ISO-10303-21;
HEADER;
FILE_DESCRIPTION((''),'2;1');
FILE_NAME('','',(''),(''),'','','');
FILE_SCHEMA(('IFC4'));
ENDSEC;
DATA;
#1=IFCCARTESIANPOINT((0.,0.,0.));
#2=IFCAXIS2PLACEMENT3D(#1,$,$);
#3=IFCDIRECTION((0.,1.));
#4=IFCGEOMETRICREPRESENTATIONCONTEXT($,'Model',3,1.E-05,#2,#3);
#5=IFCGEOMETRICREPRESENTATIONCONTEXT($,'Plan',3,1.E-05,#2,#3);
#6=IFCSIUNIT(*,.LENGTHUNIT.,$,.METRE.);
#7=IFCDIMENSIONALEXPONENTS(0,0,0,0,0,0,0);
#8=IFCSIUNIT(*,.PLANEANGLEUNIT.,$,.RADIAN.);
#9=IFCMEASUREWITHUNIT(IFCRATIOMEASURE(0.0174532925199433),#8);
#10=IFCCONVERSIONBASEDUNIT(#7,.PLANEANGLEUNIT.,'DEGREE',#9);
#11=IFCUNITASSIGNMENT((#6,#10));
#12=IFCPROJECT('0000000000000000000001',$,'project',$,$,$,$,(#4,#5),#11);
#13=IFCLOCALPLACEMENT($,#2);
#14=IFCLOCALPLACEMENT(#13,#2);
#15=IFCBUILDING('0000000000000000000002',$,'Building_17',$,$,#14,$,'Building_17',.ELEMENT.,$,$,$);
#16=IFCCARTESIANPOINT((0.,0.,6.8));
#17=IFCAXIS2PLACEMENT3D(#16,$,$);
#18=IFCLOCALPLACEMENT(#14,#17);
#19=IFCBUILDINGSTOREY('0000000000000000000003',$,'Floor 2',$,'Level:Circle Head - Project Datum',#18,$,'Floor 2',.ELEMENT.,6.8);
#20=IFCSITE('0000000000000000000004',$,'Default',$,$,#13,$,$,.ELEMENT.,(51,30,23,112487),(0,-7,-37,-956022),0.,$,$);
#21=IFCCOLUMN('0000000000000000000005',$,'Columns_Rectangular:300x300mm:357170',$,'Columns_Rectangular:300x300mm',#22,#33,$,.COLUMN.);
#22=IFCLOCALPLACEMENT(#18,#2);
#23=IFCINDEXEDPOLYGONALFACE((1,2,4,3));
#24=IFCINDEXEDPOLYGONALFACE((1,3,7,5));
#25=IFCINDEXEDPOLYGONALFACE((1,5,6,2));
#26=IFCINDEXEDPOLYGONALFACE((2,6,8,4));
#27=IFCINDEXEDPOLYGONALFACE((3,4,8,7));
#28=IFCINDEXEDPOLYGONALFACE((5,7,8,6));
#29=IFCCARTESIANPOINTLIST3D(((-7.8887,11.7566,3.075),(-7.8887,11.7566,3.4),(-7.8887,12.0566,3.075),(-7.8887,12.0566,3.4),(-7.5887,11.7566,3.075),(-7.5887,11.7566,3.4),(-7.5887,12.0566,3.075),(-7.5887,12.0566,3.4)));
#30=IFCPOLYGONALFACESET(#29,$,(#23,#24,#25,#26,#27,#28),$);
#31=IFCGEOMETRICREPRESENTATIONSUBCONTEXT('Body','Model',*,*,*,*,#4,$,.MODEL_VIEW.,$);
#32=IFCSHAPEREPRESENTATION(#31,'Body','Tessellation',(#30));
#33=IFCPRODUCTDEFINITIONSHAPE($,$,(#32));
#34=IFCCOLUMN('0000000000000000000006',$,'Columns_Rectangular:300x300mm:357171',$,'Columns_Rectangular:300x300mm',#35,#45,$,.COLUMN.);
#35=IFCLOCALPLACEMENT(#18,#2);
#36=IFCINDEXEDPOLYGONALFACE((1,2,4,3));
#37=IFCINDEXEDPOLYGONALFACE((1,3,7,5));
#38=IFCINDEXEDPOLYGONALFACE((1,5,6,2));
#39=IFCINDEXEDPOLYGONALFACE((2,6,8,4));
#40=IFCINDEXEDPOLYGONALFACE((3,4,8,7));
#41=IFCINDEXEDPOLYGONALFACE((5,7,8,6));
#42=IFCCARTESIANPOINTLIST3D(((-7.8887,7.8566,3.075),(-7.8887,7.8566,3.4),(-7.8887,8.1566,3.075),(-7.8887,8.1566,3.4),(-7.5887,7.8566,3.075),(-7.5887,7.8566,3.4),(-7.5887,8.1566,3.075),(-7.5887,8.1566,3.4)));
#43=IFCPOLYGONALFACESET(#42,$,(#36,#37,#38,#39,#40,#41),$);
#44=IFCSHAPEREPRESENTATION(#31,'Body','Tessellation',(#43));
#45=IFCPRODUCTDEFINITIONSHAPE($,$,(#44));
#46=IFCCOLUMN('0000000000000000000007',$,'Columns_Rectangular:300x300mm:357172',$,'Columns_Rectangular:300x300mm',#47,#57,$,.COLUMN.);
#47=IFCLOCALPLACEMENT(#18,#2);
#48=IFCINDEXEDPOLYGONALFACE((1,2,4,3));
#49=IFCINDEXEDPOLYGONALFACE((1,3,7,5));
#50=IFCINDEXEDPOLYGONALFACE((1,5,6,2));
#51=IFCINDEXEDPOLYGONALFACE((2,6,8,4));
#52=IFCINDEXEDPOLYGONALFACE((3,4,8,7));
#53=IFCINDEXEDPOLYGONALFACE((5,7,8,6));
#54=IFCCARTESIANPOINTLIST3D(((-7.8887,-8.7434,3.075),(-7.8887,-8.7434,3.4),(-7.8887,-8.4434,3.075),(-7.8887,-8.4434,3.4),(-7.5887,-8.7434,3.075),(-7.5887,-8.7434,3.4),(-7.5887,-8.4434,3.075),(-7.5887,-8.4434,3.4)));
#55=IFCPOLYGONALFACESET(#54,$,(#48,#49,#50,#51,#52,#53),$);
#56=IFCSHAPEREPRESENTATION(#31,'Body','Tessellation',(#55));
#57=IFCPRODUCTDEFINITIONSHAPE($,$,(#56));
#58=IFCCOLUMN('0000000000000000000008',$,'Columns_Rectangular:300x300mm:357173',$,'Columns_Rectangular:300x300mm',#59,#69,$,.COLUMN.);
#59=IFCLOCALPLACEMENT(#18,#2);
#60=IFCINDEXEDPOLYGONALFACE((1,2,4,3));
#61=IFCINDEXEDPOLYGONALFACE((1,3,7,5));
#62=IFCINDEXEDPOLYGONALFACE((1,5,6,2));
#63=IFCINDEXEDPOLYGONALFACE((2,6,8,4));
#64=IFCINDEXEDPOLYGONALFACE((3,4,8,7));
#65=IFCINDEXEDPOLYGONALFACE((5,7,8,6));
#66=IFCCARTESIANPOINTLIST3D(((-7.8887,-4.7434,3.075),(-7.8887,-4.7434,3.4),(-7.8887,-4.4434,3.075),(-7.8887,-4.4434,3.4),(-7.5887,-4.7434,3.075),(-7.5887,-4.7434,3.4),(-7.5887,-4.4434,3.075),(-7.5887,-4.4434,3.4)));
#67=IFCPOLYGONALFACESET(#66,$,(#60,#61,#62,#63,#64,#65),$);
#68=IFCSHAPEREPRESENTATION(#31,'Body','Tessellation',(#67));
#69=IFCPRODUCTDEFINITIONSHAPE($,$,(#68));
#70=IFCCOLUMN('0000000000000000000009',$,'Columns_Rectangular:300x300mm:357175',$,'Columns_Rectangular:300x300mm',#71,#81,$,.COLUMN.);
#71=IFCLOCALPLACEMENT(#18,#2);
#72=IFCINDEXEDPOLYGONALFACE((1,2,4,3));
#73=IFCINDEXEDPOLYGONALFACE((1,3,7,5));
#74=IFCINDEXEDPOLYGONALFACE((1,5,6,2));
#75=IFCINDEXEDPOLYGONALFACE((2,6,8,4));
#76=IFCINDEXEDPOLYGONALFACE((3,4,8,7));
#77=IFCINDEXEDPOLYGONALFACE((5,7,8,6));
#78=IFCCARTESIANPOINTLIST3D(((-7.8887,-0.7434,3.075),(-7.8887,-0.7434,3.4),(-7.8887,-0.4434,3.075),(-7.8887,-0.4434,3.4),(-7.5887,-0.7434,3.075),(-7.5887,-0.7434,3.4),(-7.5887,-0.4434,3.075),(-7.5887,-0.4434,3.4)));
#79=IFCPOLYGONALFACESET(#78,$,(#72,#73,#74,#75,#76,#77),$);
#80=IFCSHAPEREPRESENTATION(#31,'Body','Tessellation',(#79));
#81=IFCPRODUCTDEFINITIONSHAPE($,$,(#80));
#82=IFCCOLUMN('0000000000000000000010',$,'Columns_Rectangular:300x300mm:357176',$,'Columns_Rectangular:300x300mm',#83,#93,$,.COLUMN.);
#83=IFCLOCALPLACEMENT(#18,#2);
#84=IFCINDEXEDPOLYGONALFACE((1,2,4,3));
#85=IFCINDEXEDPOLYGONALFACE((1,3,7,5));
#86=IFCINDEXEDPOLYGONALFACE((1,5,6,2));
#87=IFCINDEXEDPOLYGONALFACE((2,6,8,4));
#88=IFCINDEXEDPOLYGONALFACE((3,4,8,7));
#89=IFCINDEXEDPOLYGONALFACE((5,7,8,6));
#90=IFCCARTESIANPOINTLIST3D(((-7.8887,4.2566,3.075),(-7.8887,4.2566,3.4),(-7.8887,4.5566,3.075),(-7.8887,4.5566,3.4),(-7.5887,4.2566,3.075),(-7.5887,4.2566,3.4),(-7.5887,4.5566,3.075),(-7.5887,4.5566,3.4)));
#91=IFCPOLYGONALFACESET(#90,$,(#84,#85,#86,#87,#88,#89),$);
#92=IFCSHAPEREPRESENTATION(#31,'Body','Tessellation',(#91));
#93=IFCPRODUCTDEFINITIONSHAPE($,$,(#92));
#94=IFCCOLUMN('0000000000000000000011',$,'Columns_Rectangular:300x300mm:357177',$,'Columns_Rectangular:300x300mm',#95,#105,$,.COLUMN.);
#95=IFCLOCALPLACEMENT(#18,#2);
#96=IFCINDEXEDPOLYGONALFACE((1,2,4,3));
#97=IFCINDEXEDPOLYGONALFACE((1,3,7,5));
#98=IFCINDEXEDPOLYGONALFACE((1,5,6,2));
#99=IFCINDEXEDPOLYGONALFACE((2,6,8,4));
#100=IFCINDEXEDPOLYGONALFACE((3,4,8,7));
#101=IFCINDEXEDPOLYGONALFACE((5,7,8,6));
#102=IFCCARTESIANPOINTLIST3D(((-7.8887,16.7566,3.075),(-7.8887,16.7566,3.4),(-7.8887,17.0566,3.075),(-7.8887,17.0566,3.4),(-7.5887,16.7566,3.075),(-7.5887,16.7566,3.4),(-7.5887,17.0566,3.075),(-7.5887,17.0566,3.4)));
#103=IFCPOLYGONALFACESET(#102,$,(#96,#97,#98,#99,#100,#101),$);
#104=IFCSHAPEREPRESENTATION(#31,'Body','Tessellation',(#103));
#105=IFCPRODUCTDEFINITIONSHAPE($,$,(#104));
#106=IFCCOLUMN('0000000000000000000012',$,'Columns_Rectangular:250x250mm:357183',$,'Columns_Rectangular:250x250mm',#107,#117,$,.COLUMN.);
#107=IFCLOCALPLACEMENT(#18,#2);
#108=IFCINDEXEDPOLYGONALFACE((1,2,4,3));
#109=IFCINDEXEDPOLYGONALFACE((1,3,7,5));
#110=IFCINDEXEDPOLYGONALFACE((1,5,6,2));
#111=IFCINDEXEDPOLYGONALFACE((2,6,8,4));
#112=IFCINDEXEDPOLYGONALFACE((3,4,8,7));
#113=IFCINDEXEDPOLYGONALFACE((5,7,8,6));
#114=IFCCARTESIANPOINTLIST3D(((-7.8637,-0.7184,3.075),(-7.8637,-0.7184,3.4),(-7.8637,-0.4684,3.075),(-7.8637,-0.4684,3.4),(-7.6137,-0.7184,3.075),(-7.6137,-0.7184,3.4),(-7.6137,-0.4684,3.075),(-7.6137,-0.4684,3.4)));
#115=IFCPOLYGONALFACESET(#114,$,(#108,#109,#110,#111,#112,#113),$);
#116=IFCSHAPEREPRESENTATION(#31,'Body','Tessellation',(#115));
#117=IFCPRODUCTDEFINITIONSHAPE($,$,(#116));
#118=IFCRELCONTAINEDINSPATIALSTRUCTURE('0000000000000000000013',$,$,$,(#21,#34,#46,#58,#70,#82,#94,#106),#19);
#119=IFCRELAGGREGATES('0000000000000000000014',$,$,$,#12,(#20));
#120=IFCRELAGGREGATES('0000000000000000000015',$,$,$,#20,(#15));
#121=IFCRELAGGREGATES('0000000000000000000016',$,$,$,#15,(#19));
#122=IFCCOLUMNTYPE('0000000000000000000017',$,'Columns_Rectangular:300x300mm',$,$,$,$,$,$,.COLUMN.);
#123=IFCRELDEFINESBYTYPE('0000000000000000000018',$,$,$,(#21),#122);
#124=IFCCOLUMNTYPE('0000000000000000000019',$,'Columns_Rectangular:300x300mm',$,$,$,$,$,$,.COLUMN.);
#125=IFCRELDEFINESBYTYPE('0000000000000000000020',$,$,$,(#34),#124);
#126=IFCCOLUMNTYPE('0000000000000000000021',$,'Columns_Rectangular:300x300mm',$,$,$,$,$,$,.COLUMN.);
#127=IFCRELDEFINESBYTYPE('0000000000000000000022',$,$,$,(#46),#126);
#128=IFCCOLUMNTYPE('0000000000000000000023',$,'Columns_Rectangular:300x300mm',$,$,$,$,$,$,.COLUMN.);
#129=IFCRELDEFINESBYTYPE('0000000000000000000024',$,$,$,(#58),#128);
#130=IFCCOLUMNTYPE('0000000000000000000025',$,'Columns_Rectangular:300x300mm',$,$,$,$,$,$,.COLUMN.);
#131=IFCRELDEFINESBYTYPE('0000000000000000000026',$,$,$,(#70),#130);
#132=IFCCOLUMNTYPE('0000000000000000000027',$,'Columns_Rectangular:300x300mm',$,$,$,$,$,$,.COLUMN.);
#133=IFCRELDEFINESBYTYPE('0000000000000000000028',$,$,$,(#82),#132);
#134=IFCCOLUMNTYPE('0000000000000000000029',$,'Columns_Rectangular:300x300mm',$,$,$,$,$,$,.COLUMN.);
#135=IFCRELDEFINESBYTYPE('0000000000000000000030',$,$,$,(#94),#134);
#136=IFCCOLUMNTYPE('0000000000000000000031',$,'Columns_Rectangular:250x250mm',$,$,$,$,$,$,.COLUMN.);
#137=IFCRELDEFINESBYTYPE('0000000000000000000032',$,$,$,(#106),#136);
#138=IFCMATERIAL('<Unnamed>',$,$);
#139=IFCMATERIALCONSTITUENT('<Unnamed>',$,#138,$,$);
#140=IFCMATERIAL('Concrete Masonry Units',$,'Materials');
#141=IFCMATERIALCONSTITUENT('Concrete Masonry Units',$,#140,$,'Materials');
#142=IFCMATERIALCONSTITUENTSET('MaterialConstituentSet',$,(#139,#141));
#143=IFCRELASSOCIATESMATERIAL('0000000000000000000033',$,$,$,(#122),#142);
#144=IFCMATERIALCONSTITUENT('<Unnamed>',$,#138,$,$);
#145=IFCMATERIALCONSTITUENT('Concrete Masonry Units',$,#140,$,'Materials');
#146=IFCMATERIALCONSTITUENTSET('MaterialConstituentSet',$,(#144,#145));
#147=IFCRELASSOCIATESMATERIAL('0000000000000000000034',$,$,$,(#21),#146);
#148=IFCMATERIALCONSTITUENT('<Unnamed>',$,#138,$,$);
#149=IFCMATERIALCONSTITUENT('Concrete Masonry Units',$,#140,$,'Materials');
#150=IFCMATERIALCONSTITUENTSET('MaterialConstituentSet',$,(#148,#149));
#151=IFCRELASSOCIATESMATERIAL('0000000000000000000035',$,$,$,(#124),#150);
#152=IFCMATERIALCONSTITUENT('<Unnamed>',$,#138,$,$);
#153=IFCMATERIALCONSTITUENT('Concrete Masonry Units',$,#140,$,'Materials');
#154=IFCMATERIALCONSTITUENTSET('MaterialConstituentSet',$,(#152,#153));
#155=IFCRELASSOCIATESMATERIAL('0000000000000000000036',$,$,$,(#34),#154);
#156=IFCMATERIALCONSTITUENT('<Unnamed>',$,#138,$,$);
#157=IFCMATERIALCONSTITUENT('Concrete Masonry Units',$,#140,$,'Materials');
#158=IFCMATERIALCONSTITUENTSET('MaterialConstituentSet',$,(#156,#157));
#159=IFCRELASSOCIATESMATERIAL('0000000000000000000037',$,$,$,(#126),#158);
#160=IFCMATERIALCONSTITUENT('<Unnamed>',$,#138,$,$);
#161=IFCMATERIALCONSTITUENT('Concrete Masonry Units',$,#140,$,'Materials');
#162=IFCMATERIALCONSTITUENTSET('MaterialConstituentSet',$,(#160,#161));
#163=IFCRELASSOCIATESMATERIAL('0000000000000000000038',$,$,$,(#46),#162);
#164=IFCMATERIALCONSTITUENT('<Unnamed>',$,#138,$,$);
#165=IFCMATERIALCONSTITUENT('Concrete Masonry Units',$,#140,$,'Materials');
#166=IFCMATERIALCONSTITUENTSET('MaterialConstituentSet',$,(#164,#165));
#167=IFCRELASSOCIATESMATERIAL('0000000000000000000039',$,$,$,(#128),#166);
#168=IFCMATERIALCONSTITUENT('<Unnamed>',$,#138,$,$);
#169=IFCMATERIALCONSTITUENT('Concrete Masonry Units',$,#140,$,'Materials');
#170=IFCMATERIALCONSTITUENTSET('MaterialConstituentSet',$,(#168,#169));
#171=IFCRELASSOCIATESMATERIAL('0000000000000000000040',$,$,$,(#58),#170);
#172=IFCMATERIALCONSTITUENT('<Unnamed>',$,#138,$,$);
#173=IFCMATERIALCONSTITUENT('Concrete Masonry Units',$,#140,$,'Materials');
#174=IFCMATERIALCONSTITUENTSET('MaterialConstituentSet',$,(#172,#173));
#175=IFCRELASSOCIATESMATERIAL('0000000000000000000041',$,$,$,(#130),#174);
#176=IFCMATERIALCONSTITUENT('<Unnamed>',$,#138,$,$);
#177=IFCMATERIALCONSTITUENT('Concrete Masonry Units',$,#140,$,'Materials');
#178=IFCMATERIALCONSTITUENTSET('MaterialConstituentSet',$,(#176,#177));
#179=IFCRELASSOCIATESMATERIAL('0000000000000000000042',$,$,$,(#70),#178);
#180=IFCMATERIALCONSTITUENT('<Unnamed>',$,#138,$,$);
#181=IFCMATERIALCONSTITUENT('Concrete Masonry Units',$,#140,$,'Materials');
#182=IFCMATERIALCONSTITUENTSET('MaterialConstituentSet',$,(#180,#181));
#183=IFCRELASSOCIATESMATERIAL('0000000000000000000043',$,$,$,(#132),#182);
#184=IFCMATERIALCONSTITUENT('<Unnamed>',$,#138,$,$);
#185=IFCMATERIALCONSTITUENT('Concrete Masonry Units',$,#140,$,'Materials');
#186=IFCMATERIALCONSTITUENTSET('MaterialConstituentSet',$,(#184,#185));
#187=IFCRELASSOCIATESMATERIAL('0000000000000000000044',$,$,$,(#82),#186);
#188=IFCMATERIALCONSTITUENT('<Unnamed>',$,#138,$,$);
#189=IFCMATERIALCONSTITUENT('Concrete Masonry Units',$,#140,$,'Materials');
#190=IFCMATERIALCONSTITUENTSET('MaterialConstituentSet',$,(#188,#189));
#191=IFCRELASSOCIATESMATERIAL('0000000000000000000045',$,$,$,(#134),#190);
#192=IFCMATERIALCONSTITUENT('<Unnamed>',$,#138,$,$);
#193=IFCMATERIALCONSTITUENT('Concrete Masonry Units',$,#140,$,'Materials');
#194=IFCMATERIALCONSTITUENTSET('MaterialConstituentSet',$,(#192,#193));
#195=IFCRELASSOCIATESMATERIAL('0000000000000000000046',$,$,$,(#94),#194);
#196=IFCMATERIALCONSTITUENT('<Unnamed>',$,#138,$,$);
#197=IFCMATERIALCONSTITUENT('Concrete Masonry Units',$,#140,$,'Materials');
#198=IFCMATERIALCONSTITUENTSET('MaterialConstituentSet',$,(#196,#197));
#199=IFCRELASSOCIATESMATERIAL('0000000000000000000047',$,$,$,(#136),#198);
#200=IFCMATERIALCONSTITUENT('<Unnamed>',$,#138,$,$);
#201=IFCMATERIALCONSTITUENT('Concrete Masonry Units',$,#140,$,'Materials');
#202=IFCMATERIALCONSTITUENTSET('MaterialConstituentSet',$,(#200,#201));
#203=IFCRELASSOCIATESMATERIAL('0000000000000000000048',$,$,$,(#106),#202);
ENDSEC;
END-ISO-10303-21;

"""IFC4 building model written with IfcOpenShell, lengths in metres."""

from ifc_helpers import new_model, entity, si_unit, converted_unit, direction, frame, origin, place, context, subcontext, project, spatial, indexed_curve, outline, extrude, source, transform, mapped, material, constituent, constituent_set, type_object, type_shapes, element, save


model = new_model("IFC4")

# Units and contexts
model_context = context("Model", 3, precision=1e-05, world=origin(), true_north=direction((0.0, 1.0)))
plan_context = context("Plan", 3, precision=1e-05, world=origin(), true_north=direction((0.0, 1.0)))
body_context = subcontext(model_context, "Body", "Model", "MODEL_VIEW")
ifc_project = project(units=[si_unit("LENGTHUNIT", "METRE"), converted_unit("PLANEANGLEUNIT", "DEGREE", entity("IfcRatioMeasure", 0.0174532925199433), si_unit("PLANEANGLEUNIT", "RADIAN"), dimensions=[0, 0, 0, 0, 0, 0, 0])], contexts=[model_context, plan_context])

# Site, building, storey
site_placement = place(None, origin())
site = spatial("IfcSite", under=ifc_project, at=site_placement, Name="Default", CompositionType="ELEMENT", RefLatitude=(51, 30, 23, 112487), RefLongitude=(0, -7, -37, -956022), RefElevation=0.0)
building_placement = place(site_placement, origin())
building = spatial("IfcBuilding", under=site, at=building_placement, Name="Building_17", LongName="Building_17", CompositionType="ELEMENT")
storey_placement = place(building_placement, frame((0.0, 0.0, 6.8)))
storey = spatial("IfcBuildingStorey", under=building, at=storey_placement, Name="Floor 2", ObjectType="Level:Circle Head - Project Datum", LongName="Floor 2", CompositionType="ELEMENT", Elevation=6.8)

# Columns
ifc_material_1 = material(Name="<Unnamed>")
ifc_constituent_1 = constituent(ifc_material_1, Name="<Unnamed>")
ifc_material_2 = material(Name="Concrete Masonry Units", Category="Materials")
ifc_constituent_2 = constituent(ifc_material_2, Name="Concrete Masonry Units", Category="Materials")
ifc_constituent_set_1 = constituent_set(constituents=[ifc_constituent_1, ifc_constituent_2], Name="MaterialConstituentSet")
ifc_constituent_3 = constituent(ifc_material_1, Name="<Unnamed>")
ifc_constituent_4 = constituent(ifc_material_2, Name="Concrete Masonry Units", Category="Materials")
ifc_constituent_set_2 = constituent_set(constituents=[ifc_constituent_3, ifc_constituent_4], Name="MaterialConstituentSet")
column_type_1 = type_object("IfcColumnType", Name="Columns_Rectangular:300x300mm", PredefinedType="COLUMN", material=ifc_constituent_set_2)
shared_shape_1 = source(origin(), body_context, "Body", "SweptSolid", [
    extrude(outline(indexed_curve([(-0.15, -0.15), (0.15, -0.15), (0.15, 0.15), (-0.15, 0.15), (-0.15, -0.15)], self_intersect=False)), frame((-7.7387, 11.9066, 9.875), z_axis=(0.0, 0.0, 1.0), x_axis=(0.0, -1.0, 0.0)), (0.0, 0.0, 1.0), 0.325),
])
type_shapes(column_type_1, [shared_shape_1])
column_1_placement = place(storey_placement, frame((0.0, 0.0, -6.8)))
element("IfcColumn", 1, at=column_1_placement, inside=storey, type_object=column_type_1, material=ifc_constituent_set_1, Name="Columns_Rectangular:300x300mm:357170", ObjectType="Columns_Rectangular:300x300mm", PredefinedType="COLUMN", context=body_context, shape_type="MappedRepresentation", body=[
    mapped(shared_shape_1, transform((0.0, 0.0, 0.0), scale=1.0)),
])
ifc_constituent_5 = constituent(ifc_material_1, Name="<Unnamed>")
ifc_constituent_6 = constituent(ifc_material_2, Name="Concrete Masonry Units", Category="Materials")
ifc_constituent_set_3 = constituent_set(constituents=[ifc_constituent_5, ifc_constituent_6], Name="MaterialConstituentSet")
ifc_constituent_7 = constituent(ifc_material_1, Name="<Unnamed>")
ifc_constituent_8 = constituent(ifc_material_2, Name="Concrete Masonry Units", Category="Materials")
ifc_constituent_set_4 = constituent_set(constituents=[ifc_constituent_7, ifc_constituent_8], Name="MaterialConstituentSet")
column_type_2 = type_object("IfcColumnType", Name="Columns_Rectangular:300x300mm", PredefinedType="COLUMN", material=ifc_constituent_set_4)
shared_shape_2 = source(origin(), body_context, "Body", "SweptSolid", [
    extrude(outline(indexed_curve([(-0.15, -0.15), (0.15, -0.15), (0.15, 0.15), (-0.15, 0.15), (-0.15, -0.15)], self_intersect=False)), frame((-7.7387, 8.0066, 9.875), z_axis=(0.0, 0.0, 1.0), x_axis=(0.0, -1.0, 0.0)), (0.0, 0.0, 1.0), 0.325),
])
type_shapes(column_type_2, [shared_shape_2])
column_2_placement = place(storey_placement, frame((0.0, 0.0, -6.8)))
element("IfcColumn", 2, at=column_2_placement, inside=storey, type_object=column_type_2, material=ifc_constituent_set_3, Name="Columns_Rectangular:300x300mm:357171", ObjectType="Columns_Rectangular:300x300mm", PredefinedType="COLUMN", context=body_context, shape_type="MappedRepresentation", body=[
    mapped(shared_shape_2, transform((0.0, 0.0, 0.0), scale=1.0)),
])
ifc_constituent_9 = constituent(ifc_material_1, Name="<Unnamed>")
ifc_constituent_10 = constituent(ifc_material_2, Name="Concrete Masonry Units", Category="Materials")
ifc_constituent_set_5 = constituent_set(constituents=[ifc_constituent_9, ifc_constituent_10], Name="MaterialConstituentSet")
ifc_constituent_11 = constituent(ifc_material_1, Name="<Unnamed>")
ifc_constituent_12 = constituent(ifc_material_2, Name="Concrete Masonry Units", Category="Materials")
ifc_constituent_set_6 = constituent_set(constituents=[ifc_constituent_11, ifc_constituent_12], Name="MaterialConstituentSet")
column_type_3 = type_object("IfcColumnType", Name="Columns_Rectangular:300x300mm", PredefinedType="COLUMN", material=ifc_constituent_set_6)
shared_shape_3 = source(origin(), body_context, "Body", "SweptSolid", [
    extrude(outline(indexed_curve([(-0.15, -0.15), (0.15, -0.15), (0.15, 0.15), (-0.15, 0.15), (-0.15, -0.15)], self_intersect=False)), frame((-7.7387, -8.5934, 9.875), z_axis=(0.0, 0.0, 1.0), x_axis=(0.0, -1.0, 0.0)), (0.0, 0.0, 1.0), 0.325),
])
type_shapes(column_type_3, [shared_shape_3])
column_3_placement = place(storey_placement, frame((0.0, 0.0, -6.8)))
element("IfcColumn", 3, at=column_3_placement, inside=storey, type_object=column_type_3, material=ifc_constituent_set_5, Name="Columns_Rectangular:300x300mm:357172", ObjectType="Columns_Rectangular:300x300mm", PredefinedType="COLUMN", context=body_context, shape_type="MappedRepresentation", body=[
    mapped(shared_shape_3, transform((0.0, 0.0, 0.0), scale=1.0)),
])
ifc_constituent_13 = constituent(ifc_material_1, Name="<Unnamed>")
ifc_constituent_14 = constituent(ifc_material_2, Name="Concrete Masonry Units", Category="Materials")
ifc_constituent_set_7 = constituent_set(constituents=[ifc_constituent_13, ifc_constituent_14], Name="MaterialConstituentSet")
ifc_constituent_15 = constituent(ifc_material_1, Name="<Unnamed>")
ifc_constituent_16 = constituent(ifc_material_2, Name="Concrete Masonry Units", Category="Materials")
ifc_constituent_set_8 = constituent_set(constituents=[ifc_constituent_15, ifc_constituent_16], Name="MaterialConstituentSet")
column_type_4 = type_object("IfcColumnType", Name="Columns_Rectangular:300x300mm", PredefinedType="COLUMN", material=ifc_constituent_set_8)
shared_shape_4 = source(origin(), body_context, "Body", "SweptSolid", [
    extrude(outline(indexed_curve([(-0.15, -0.15), (0.15, -0.15), (0.15, 0.15), (-0.15, 0.15), (-0.15, -0.15)], self_intersect=False)), frame((-7.7387, -4.5934, 9.875), z_axis=(0.0, 0.0, 1.0), x_axis=(0.0, -1.0, 0.0)), (0.0, 0.0, 1.0), 0.325),
])
type_shapes(column_type_4, [shared_shape_4])
column_4_placement = place(storey_placement, frame((0.0, 0.0, -6.8)))
element("IfcColumn", 4, at=column_4_placement, inside=storey, type_object=column_type_4, material=ifc_constituent_set_7, Name="Columns_Rectangular:300x300mm:357173", ObjectType="Columns_Rectangular:300x300mm", PredefinedType="COLUMN", context=body_context, shape_type="MappedRepresentation", body=[
    mapped(shared_shape_4, transform((0.0, 0.0, 0.0), scale=1.0)),
])
ifc_constituent_17 = constituent(ifc_material_1, Name="<Unnamed>")
ifc_constituent_18 = constituent(ifc_material_2, Name="Concrete Masonry Units", Category="Materials")
ifc_constituent_set_9 = constituent_set(constituents=[ifc_constituent_17, ifc_constituent_18], Name="MaterialConstituentSet")
ifc_constituent_19 = constituent(ifc_material_1, Name="<Unnamed>")
ifc_constituent_20 = constituent(ifc_material_2, Name="Concrete Masonry Units", Category="Materials")
ifc_constituent_set_10 = constituent_set(constituents=[ifc_constituent_19, ifc_constituent_20], Name="MaterialConstituentSet")
column_type_5 = type_object("IfcColumnType", Name="Columns_Rectangular:300x300mm", PredefinedType="COLUMN", material=ifc_constituent_set_10)
shared_shape_5 = source(origin(), body_context, "Body", "SweptSolid", [
    extrude(outline(indexed_curve([(-0.15, -0.15), (0.15, -0.15), (0.15, 0.15), (-0.15, 0.15), (-0.15, -0.15)], self_intersect=False)), frame((-7.7387, -0.5934, 9.875), z_axis=(0.0, 0.0, 1.0), x_axis=(0.0, -1.0, 0.0)), (0.0, 0.0, 1.0), 0.325),
])
type_shapes(column_type_5, [shared_shape_5])
column_5_placement = place(storey_placement, frame((0.0, 0.0, -6.8)))
element("IfcColumn", 5, at=column_5_placement, inside=storey, type_object=column_type_5, material=ifc_constituent_set_9, Name="Columns_Rectangular:300x300mm:357175", ObjectType="Columns_Rectangular:300x300mm", PredefinedType="COLUMN", context=body_context, shape_type="MappedRepresentation", body=[
    mapped(shared_shape_5, transform((0.0, 0.0, 0.0), scale=1.0)),
])
ifc_constituent_21 = constituent(ifc_material_1, Name="<Unnamed>")
ifc_constituent_22 = constituent(ifc_material_2, Name="Concrete Masonry Units", Category="Materials")
ifc_constituent_set_11 = constituent_set(constituents=[ifc_constituent_21, ifc_constituent_22], Name="MaterialConstituentSet")
ifc_constituent_23 = constituent(ifc_material_1, Name="<Unnamed>")
ifc_constituent_24 = constituent(ifc_material_2, Name="Concrete Masonry Units", Category="Materials")
ifc_constituent_set_12 = constituent_set(constituents=[ifc_constituent_23, ifc_constituent_24], Name="MaterialConstituentSet")
column_type_6 = type_object("IfcColumnType", Name="Columns_Rectangular:300x300mm", PredefinedType="COLUMN", material=ifc_constituent_set_12)
shared_shape_6 = source(origin(), body_context, "Body", "SweptSolid", [
    extrude(outline(indexed_curve([(-0.15, -0.15), (0.15, -0.15), (0.15, 0.15), (-0.15, 0.15), (-0.15, -0.15)], self_intersect=False)), frame((-7.7387, 4.4066, 9.875), z_axis=(0.0, 0.0, 1.0), x_axis=(0.0, -1.0, 0.0)), (0.0, 0.0, 1.0), 0.325),
])
type_shapes(column_type_6, [shared_shape_6])
column_6_placement = place(storey_placement, frame((0.0, 0.0, -6.8)))
element("IfcColumn", 6, at=column_6_placement, inside=storey, type_object=column_type_6, material=ifc_constituent_set_11, Name="Columns_Rectangular:300x300mm:357176", ObjectType="Columns_Rectangular:300x300mm", PredefinedType="COLUMN", context=body_context, shape_type="MappedRepresentation", body=[
    mapped(shared_shape_6, transform((0.0, 0.0, 0.0), scale=1.0)),
])
ifc_constituent_25 = constituent(ifc_material_1, Name="<Unnamed>")
ifc_constituent_26 = constituent(ifc_material_2, Name="Concrete Masonry Units", Category="Materials")
ifc_constituent_set_13 = constituent_set(constituents=[ifc_constituent_25, ifc_constituent_26], Name="MaterialConstituentSet")
ifc_constituent_27 = constituent(ifc_material_1, Name="<Unnamed>")
ifc_constituent_28 = constituent(ifc_material_2, Name="Concrete Masonry Units", Category="Materials")
ifc_constituent_set_14 = constituent_set(constituents=[ifc_constituent_27, ifc_constituent_28], Name="MaterialConstituentSet")
column_type_7 = type_object("IfcColumnType", Name="Columns_Rectangular:300x300mm", PredefinedType="COLUMN", material=ifc_constituent_set_14)
shared_shape_7 = source(origin(), body_context, "Body", "SweptSolid", [
    extrude(outline(indexed_curve([(-0.15, -0.15), (0.15, -0.15), (0.15, 0.15), (-0.15, 0.15), (-0.15, -0.15)], self_intersect=False)), frame((-7.7387, 16.9066, 9.875), z_axis=(0.0, 0.0, 1.0), x_axis=(0.0, -1.0, 0.0)), (0.0, 0.0, 1.0), 0.325),
])
type_shapes(column_type_7, [shared_shape_7])
column_7_placement = place(storey_placement, frame((0.0, 0.0, -6.8)))
element("IfcColumn", 7, at=column_7_placement, inside=storey, type_object=column_type_7, material=ifc_constituent_set_13, Name="Columns_Rectangular:300x300mm:357177", ObjectType="Columns_Rectangular:300x300mm", PredefinedType="COLUMN", context=body_context, shape_type="MappedRepresentation", body=[
    mapped(shared_shape_7, transform((0.0, 0.0, 0.0), scale=1.0)),
])
ifc_constituent_29 = constituent(ifc_material_1, Name="<Unnamed>")
ifc_constituent_30 = constituent(ifc_material_2, Name="Concrete Masonry Units", Category="Materials")
ifc_constituent_set_15 = constituent_set(constituents=[ifc_constituent_29, ifc_constituent_30], Name="MaterialConstituentSet")
ifc_constituent_31 = constituent(ifc_material_1, Name="<Unnamed>")
ifc_constituent_32 = constituent(ifc_material_2, Name="Concrete Masonry Units", Category="Materials")
ifc_constituent_set_16 = constituent_set(constituents=[ifc_constituent_31, ifc_constituent_32], Name="MaterialConstituentSet")
column_type_8 = type_object("IfcColumnType", Name="Columns_Rectangular:250x250mm", PredefinedType="COLUMN", material=ifc_constituent_set_16)
shared_shape_8 = source(origin(), body_context, "Body", "SweptSolid", [
    extrude(outline(indexed_curve([(-0.125, -0.125), (0.125, -0.125), (0.125, 0.125), (-0.125, 0.125), (-0.125, -0.125)], self_intersect=False)), frame((-7.7387, -0.5934, 9.875), z_axis=(0.0, 0.0, 1.0), x_axis=(0.0, -1.0, 0.0)), (0.0, 0.0, 1.0), 0.325),
])
type_shapes(column_type_8, [shared_shape_8])
column_8_placement = place(storey_placement, frame((0.0, 0.0, -6.8)))
element("IfcColumn", 8, at=column_8_placement, inside=storey, type_object=column_type_8, material=ifc_constituent_set_15, Name="Columns_Rectangular:250x250mm:357183", ObjectType="Columns_Rectangular:250x250mm", PredefinedType="COLUMN", context=body_context, shape_type="MappedRepresentation", body=[
    mapped(shared_shape_8, transform((0.0, 0.0, 0.0), scale=1.0)),
])

save(model, "model.ifc")
